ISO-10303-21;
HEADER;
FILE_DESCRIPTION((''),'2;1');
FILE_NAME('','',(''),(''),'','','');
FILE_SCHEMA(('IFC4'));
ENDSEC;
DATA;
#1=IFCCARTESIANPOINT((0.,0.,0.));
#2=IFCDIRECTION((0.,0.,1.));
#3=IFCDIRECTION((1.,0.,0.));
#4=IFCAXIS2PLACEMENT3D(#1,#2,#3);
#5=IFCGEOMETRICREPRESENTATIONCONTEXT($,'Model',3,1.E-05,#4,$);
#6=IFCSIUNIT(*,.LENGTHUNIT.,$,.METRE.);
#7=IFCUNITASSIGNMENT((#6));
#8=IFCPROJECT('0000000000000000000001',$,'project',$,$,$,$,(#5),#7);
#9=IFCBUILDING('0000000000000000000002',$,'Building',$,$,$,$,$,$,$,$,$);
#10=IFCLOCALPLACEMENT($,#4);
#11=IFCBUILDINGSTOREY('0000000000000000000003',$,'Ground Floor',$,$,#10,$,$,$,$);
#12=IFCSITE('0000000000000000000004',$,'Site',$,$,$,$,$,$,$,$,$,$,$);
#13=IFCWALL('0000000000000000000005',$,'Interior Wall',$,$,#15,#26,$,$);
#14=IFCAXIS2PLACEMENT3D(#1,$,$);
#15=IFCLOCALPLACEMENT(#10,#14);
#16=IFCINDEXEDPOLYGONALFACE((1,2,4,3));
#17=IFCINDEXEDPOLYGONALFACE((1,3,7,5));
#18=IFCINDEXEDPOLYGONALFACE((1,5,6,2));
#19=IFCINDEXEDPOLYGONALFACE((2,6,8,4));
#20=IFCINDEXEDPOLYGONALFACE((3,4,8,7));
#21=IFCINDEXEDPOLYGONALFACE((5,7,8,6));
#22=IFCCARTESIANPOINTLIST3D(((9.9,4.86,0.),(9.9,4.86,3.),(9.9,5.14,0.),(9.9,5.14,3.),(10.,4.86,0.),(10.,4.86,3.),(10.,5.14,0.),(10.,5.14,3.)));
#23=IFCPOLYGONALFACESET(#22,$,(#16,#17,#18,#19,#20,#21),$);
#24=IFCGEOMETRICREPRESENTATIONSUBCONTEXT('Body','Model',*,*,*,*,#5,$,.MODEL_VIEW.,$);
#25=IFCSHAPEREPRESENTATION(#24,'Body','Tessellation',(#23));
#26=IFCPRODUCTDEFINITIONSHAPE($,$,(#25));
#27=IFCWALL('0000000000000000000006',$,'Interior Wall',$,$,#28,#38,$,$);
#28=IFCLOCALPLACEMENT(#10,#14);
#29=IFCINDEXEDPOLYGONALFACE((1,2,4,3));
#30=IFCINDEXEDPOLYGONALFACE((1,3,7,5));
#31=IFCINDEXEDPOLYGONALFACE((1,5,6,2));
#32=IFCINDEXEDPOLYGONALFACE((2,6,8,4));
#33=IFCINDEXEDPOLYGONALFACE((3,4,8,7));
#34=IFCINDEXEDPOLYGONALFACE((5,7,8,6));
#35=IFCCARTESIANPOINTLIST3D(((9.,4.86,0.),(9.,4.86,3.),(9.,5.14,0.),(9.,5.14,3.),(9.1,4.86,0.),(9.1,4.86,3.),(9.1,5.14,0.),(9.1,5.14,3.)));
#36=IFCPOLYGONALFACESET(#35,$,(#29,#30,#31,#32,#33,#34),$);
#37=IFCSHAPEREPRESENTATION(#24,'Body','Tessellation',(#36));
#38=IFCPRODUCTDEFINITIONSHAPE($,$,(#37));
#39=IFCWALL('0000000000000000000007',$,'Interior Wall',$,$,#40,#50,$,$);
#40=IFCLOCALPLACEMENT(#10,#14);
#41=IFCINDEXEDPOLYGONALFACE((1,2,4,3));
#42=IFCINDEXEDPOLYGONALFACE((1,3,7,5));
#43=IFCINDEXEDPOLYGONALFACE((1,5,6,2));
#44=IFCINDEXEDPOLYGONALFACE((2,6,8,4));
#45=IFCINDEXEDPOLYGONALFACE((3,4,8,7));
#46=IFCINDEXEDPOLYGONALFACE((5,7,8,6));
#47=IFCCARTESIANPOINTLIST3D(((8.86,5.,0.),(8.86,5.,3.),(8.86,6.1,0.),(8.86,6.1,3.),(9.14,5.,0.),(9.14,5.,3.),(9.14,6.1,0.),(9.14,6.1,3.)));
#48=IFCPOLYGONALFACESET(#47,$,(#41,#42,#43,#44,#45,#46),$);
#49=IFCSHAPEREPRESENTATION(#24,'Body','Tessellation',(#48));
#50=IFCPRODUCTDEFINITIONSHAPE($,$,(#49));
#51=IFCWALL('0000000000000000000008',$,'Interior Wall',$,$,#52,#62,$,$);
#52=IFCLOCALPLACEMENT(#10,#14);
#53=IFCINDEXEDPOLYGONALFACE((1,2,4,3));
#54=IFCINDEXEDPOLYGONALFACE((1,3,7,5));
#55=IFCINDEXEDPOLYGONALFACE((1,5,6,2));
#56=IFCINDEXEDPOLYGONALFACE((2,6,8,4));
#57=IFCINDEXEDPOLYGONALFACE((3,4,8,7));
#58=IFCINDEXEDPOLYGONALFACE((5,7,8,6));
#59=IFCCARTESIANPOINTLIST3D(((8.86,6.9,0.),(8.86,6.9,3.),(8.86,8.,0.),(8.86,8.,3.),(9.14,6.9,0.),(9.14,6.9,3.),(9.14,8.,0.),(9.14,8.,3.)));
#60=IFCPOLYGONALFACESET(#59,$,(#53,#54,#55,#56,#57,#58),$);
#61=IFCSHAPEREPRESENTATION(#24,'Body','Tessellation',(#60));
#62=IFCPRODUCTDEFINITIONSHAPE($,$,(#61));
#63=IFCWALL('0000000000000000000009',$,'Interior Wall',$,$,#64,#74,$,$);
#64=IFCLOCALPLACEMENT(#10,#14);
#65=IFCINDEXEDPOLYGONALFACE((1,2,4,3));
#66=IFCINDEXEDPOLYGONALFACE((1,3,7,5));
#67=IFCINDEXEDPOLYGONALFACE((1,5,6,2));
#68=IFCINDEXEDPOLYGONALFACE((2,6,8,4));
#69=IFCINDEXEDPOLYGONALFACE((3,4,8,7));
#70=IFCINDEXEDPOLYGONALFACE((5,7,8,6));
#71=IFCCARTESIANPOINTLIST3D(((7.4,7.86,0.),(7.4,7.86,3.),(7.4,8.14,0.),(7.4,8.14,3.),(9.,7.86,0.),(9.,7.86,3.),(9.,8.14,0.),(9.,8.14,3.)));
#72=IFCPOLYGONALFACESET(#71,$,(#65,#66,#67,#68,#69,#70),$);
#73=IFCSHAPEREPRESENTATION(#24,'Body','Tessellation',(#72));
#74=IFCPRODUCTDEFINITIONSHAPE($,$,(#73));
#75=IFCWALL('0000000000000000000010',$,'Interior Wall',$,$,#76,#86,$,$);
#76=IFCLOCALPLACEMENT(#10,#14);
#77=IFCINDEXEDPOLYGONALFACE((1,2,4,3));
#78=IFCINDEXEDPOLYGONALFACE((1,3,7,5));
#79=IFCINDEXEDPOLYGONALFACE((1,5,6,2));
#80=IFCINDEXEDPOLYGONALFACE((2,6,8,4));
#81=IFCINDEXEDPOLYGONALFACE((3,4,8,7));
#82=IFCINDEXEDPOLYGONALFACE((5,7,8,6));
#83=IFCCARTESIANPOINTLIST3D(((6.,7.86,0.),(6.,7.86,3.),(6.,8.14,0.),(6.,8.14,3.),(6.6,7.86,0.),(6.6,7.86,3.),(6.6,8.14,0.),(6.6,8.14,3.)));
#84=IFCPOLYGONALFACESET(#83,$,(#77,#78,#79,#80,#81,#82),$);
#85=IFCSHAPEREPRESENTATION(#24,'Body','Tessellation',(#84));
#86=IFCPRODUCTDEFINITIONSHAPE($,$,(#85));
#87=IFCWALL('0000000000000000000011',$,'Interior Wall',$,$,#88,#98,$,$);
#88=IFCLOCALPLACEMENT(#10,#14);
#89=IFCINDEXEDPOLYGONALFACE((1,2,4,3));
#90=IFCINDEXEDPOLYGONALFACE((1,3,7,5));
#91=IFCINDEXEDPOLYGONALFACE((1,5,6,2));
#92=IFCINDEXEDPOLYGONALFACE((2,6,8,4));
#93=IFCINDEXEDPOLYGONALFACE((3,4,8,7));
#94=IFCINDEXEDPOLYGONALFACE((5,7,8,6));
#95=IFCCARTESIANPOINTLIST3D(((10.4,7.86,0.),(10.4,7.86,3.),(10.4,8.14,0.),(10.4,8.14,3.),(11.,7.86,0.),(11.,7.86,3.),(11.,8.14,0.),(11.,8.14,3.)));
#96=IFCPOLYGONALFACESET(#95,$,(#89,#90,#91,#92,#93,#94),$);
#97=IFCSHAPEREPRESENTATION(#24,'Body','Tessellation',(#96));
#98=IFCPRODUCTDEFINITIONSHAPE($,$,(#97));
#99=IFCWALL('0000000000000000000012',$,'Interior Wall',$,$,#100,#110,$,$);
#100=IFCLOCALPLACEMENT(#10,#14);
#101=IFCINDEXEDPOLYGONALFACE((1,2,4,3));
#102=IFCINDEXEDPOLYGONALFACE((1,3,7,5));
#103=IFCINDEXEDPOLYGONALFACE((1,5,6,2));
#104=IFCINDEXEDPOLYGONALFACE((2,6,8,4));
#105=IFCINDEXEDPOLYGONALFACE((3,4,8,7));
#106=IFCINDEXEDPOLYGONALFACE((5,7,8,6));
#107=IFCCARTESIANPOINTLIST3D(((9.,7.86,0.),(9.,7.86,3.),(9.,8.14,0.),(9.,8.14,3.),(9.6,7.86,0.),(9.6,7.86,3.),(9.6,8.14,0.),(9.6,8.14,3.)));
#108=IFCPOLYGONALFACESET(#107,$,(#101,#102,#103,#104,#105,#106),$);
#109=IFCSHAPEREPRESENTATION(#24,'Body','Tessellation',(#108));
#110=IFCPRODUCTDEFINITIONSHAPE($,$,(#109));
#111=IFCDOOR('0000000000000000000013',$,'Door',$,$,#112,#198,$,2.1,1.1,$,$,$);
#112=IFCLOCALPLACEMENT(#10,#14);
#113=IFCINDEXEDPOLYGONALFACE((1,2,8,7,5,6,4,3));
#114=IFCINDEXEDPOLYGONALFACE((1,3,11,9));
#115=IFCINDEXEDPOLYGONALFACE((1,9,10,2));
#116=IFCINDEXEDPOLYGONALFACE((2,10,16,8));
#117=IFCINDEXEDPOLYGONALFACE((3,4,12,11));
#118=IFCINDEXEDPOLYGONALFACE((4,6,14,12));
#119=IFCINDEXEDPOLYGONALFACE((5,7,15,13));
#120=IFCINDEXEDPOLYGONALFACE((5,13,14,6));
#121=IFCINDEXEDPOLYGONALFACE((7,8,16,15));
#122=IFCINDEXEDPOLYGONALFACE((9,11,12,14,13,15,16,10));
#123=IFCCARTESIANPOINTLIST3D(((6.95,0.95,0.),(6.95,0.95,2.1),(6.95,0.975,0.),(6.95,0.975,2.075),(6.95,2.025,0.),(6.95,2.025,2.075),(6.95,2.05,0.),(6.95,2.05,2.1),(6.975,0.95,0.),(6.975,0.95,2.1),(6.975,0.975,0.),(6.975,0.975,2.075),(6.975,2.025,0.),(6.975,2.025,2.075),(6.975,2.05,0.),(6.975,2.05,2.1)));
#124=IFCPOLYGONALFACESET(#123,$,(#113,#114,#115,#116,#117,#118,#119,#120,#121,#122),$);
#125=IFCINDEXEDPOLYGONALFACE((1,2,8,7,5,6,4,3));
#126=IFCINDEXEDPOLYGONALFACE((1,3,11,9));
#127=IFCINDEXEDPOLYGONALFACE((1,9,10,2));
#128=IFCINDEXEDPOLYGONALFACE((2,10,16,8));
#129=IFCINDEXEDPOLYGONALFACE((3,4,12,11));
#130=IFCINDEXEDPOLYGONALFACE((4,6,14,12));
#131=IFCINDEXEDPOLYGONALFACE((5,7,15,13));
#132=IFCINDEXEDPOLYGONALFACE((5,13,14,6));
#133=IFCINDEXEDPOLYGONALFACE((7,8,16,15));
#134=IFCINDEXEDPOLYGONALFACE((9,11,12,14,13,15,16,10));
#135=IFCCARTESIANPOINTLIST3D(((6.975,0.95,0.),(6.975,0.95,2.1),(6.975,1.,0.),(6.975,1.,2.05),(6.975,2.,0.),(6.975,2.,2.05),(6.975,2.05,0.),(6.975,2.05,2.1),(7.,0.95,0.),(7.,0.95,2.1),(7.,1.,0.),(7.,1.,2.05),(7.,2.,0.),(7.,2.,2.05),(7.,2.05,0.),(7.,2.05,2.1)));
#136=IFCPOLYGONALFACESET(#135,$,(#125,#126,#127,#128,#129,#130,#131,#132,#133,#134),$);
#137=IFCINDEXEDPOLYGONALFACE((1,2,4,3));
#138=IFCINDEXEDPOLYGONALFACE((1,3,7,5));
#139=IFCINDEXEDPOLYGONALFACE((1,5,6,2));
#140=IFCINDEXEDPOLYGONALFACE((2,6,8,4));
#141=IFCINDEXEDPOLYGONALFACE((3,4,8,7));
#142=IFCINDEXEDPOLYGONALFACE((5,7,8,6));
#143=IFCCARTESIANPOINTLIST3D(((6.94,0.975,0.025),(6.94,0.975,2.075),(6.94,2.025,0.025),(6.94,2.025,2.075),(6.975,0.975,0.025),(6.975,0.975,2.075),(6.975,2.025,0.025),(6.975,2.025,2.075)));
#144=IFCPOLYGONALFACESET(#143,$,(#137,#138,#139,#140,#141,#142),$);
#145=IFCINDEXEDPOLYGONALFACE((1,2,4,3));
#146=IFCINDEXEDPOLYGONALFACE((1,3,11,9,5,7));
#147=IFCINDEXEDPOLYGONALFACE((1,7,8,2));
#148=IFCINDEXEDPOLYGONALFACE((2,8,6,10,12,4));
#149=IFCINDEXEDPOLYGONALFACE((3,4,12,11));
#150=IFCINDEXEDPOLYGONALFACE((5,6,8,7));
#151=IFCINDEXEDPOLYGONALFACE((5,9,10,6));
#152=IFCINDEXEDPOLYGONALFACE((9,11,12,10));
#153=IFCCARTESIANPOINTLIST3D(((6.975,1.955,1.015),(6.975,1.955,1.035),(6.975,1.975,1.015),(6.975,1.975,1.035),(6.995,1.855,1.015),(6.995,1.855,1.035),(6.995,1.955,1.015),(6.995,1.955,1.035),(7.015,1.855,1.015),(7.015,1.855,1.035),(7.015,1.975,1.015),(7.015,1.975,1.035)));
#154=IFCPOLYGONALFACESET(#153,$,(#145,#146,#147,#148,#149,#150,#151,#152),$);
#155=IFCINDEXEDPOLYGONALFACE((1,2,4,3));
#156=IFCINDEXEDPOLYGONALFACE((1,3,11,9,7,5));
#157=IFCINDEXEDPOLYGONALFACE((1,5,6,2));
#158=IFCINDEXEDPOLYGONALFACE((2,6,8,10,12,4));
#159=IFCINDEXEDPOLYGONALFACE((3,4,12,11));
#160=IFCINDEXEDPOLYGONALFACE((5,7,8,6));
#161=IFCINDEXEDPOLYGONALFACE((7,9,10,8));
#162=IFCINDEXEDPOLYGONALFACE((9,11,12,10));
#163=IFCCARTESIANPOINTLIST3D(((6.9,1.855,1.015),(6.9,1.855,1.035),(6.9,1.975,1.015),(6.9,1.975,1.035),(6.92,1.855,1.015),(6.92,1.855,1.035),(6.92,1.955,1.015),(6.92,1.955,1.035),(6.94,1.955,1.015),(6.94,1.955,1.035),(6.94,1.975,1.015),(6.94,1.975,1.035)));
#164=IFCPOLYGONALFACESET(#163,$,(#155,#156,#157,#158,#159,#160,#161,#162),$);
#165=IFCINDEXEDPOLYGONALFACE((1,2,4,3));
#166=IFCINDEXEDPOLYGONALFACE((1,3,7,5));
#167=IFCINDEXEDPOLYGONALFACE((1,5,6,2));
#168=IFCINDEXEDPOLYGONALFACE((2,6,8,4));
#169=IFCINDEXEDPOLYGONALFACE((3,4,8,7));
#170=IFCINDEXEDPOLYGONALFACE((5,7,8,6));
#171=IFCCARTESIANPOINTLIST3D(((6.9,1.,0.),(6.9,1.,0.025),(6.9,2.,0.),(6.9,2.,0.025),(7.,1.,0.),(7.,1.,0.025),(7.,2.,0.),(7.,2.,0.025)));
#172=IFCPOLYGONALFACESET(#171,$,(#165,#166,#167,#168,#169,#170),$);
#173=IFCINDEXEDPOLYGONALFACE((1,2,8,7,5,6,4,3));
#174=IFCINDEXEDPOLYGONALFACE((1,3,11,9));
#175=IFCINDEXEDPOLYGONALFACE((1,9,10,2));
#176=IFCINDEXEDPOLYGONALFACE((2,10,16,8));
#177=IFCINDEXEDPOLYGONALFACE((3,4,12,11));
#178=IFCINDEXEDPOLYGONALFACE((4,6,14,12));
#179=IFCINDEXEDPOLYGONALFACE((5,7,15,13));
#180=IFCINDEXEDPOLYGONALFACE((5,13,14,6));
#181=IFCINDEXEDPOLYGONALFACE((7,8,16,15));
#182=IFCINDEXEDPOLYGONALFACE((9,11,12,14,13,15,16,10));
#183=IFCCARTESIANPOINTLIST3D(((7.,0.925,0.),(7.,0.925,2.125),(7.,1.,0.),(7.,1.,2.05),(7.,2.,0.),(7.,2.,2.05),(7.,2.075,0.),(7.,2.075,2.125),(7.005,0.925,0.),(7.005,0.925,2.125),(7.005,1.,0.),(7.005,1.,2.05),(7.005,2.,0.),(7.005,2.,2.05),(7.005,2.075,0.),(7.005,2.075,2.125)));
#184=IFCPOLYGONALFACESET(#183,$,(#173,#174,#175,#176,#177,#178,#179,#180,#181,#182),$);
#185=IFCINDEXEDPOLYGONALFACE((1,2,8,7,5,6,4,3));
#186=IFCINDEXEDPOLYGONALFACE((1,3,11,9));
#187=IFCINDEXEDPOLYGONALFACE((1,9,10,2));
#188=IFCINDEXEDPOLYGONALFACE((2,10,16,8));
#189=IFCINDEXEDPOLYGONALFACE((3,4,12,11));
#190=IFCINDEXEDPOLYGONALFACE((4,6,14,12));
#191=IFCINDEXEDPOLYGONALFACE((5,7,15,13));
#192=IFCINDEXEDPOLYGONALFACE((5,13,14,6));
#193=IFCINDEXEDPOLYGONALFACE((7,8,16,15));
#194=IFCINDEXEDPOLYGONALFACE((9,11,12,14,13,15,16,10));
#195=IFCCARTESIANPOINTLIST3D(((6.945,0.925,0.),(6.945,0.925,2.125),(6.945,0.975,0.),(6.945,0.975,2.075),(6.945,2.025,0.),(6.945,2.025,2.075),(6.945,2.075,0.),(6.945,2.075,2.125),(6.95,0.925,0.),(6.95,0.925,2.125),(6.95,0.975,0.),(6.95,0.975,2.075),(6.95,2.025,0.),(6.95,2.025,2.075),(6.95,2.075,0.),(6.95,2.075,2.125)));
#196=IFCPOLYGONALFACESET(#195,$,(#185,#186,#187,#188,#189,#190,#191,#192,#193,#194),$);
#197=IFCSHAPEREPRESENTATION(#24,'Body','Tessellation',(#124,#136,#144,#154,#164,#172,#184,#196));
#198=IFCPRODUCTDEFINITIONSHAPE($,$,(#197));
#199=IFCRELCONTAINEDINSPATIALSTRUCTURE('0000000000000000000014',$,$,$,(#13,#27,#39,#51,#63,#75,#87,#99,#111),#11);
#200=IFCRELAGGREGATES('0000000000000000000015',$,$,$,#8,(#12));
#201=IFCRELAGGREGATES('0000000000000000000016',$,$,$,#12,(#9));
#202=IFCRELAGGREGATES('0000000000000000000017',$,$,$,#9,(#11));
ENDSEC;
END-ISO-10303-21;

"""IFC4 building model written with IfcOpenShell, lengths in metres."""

from ifc_helpers import new_model, si_unit, frame, origin_with_axes, place, context, subcontext, project, spatial, line, indexed_curve, outline, extrude, element, save


model = new_model("IFC4")

# Units and contexts
model_context = context("Model", 3, precision=1e-05, world=origin_with_axes())
body_context = subcontext(model_context, "Body", "Model", "MODEL_VIEW")
ifc_project = project(units=[si_unit("LENGTHUNIT", "METRE")], contexts=[model_context])

# Site, building, storey
site = spatial("IfcSite", under=ifc_project, Name="Site")
building = spatial("IfcBuilding", under=site, Name="Building")
storey_placement = place(None, origin_with_axes())
storey = spatial("IfcBuildingStorey", under=building, at=storey_placement, Name="Ground Floor")

# Walls
for number, where, z_axis, x_axis, name in (
    (1, (10.0, 5.0, 0.0), (0.0, 0.0, 1.0), (-1.0, 0.0, 0.0), "Interior Wall"),
    (2, (9.1, 5.0, 0.0), (0.0, 0.0, 1.0), (-1.0, 0.0, 0.0), "Interior Wall"),
):
    element("IfcWall", number, at=place(storey_placement, frame(where, z_axis=z_axis, x_axis=x_axis)), inside=storey, Name=name, context=body_context, shape_type="SweptSolid", body=[
        extrude(outline(indexed_curve([(0.0, 0.0), (0.0, 0.28), (0.1, 0.28), (0.1, 0.0), (0.0, 0.0)], self_intersect=False)), frame((0.0, -0.14, 0.0), z_axis=(0.0, 0.0, 1.0), x_axis=(1.0, 0.0, 0.0)), (0.0, 0.0, 1.0), 3.0),
    ])
for number, where, z_axis, x_axis, name in (
    (3, (9.0, 5.0, 0.0), (0.0, 0.0, 1.0), (0.0, 1.0, 0.0), "Interior Wall"),
    (4, (9.0, 6.9, 0.0), (0.0, 0.0, 1.0), (0.0, 1.0, 0.0), "Interior Wall"),
):
    element("IfcWall", number, at=place(storey_placement, frame(where, z_axis=z_axis, x_axis=x_axis)), inside=storey, Name=name, context=body_context, shape_type="SweptSolid", body=[
        extrude(outline(indexed_curve([(0.0, 0.0), (0.0, 0.28), (1.1, 0.28), (1.1, 0.0), (0.0, 0.0)], self_intersect=False)), frame((0.0, -0.14, 0.0), z_axis=(0.0, 0.0, 1.0), x_axis=(1.0, 0.0, 0.0)), (0.0, 0.0, 1.0), 3.0),
    ])
wall_1_placement = place(storey_placement, frame((9.0, 8.0, 0.0), z_axis=(0.0, 0.0, 1.0), x_axis=(-1.0, 0.0, 0.0)))
element("IfcWall", 5, at=wall_1_placement, inside=storey, Name="Interior Wall", context=body_context, shape_type="SweptSolid", body=[
    extrude(outline(indexed_curve([(0.0, 0.0), (0.0, 0.28), (1.6, 0.28), (1.6, 0.0), (0.0, 0.0)], self_intersect=False)), frame((0.0, -0.14, 0.0), z_axis=(0.0, 0.0, 1.0), x_axis=(1.0, 0.0, 0.0)), (0.0, 0.0, 1.0), 3.0),
])
for number, where, z_axis, x_axis, name in (
    (6, (6.6, 8.0, 0.0), (0.0, 0.0, 1.0), (-1.0, 0.0, 0.0), "Interior Wall"),
    (7, (11.0, 8.0, 0.0), (0.0, 0.0, 1.0), (-1.0, 0.0, 0.0), "Interior Wall"),
    (8, (9.6, 8.0, 0.0), (0.0, 0.0, 1.0), (-1.0, 0.0, 0.0), "Interior Wall"),
):
    element("IfcWall", number, at=place(storey_placement, frame(where, z_axis=z_axis, x_axis=x_axis)), inside=storey, Name=name, context=body_context, shape_type="SweptSolid", body=[
        extrude(outline(indexed_curve([(0.0, 0.0), (0.0, 0.28), (0.6, 0.28), (0.6, 0.0), (0.0, 0.0)], self_intersect=False)), frame((0.0, -0.14, 0.0), z_axis=(0.0, 0.0, 1.0), x_axis=(1.0, 0.0, 0.0)), (0.0, 0.0, 1.0), 3.0),
    ])

# Door
door_1_placement = place(storey_placement, frame((7.0, 0.95, 0.0), z_axis=(0.0, 0.0, 1.0), x_axis=(0.0, 1.0, 0.0)))
element("IfcDoor", 9, at=door_1_placement, inside=storey, Name="Door", OverallHeight=2.1, OverallWidth=1.1, context=body_context, shape_type="SweptSolid", body=[
    extrude(outline(indexed_curve([(0.0, 0.0), (0.0, 2.1), (1.1, 2.1), (1.1, 0.0), (1.075, 0.0), (1.075, 2.075), (0.025, 2.075), (0.025, 0.0)], segments=[line(1, 2, 3, 4, 5, 6, 7, 8, 1)])), frame((0.0, 0.025, 0.0), z_axis=(0.0, -1.0, 0.0), x_axis=(1.0, 0.0, 0.0)), (0.0, 0.0, -1.0), 0.025),
    extrude(outline(indexed_curve([(0.0, 0.0), (0.0, 2.1), (1.1, 2.1), (1.1, 0.0), (1.05, 0.0), (1.05, 2.05), (0.05, 2.05), (0.05, 0.0)], segments=[line(1, 2, 3, 4, 5, 6, 7, 8, 1)])), frame((0.0, 0.0, 0.0), z_axis=(0.0, -1.0, 0.0), x_axis=(1.0, 0.0, 0.0)), (0.0, 0.0, -1.0), 0.025),
    extrude(outline(indexed_curve([(0.0, 0.0), (1.05, 0.0), (1.05, 0.035), (0.0, 0.035)], segments=[line(1, 2, 3, 4, 1)])), frame((0.025, 0.025, 0.025), z_axis=(0.0, 0.0, 1.0), x_axis=(1.0, 0.0, 0.0)), (0.0, 0.0, 1.0), 2.05),
    extrude(outline(indexed_curve([(0.0, 0.0), (0.0, -0.04), (-0.12, -0.04), (-0.12, -0.02), (-0.02, -0.02), (-0.02, 0.0)], segments=[line(1, 2, 3, 4, 5, 6, 1)])), frame((1.025, 0.025, 1.015), z_axis=(0.0, 0.0, 1.0), x_axis=(1.0, 0.0, 0.0)), (0.0, 0.0, 1.0), 0.02),
    extrude(outline(indexed_curve([(0.0, 0.0), (0.0, 0.04), (-0.12, 0.04), (-0.12, 0.02), (-0.02, 0.02), (-0.02, 0.0)], segments=[line(1, 2, 3, 4, 5, 6, 1)])), frame((1.025, 0.06, 1.015), z_axis=(0.0, 0.0, 1.0), x_axis=(1.0, 0.0, 0.0)), (0.0, 0.0, 1.0), 0.02),
    extrude(outline(indexed_curve([(0.0, 0.0), (1.0, 0.0), (1.0, 0.1), (0.0, 0.1)], segments=[line(1, 2, 3, 4, 1)])), frame((0.05, 0.0, 0.0), z_axis=(0.0, 0.0, 1.0), x_axis=(1.0, 0.0, 0.0)), (0.0, 0.0, 1.0), 0.025),
    extrude(outline(indexed_curve([(0.0, 0.0), (0.0, 2.125), (1.15, 2.125), (1.15, 0.0), (1.075, 0.0), (1.075, 2.05), (0.075, 2.05), (0.075, 0.0)], segments=[line(1, 2, 3, 4, 5, 6, 7, 8, 1)])), frame((-0.025, -0.005, 0.0), z_axis=(0.0, -1.0, 0.0), x_axis=(1.0, 0.0, 0.0)), (0.0, 0.0, -1.0), 0.005),
    extrude(outline(indexed_curve([(0.0, 0.0), (0.0, 2.125), (1.15, 2.125), (1.15, 0.0), (1.1, 0.0), (1.1, 2.075), (0.05, 2.075), (0.05, 0.0)], segments=[line(1, 2, 3, 4, 5, 6, 7, 8, 1)])), frame((-0.025, 0.05, 0.0), z_axis=(0.0, -1.0, 0.0), x_axis=(1.0, 0.0, 0.0)), (0.0, 0.0, -1.0), 0.005),
])

save(model, "model.ifc")
